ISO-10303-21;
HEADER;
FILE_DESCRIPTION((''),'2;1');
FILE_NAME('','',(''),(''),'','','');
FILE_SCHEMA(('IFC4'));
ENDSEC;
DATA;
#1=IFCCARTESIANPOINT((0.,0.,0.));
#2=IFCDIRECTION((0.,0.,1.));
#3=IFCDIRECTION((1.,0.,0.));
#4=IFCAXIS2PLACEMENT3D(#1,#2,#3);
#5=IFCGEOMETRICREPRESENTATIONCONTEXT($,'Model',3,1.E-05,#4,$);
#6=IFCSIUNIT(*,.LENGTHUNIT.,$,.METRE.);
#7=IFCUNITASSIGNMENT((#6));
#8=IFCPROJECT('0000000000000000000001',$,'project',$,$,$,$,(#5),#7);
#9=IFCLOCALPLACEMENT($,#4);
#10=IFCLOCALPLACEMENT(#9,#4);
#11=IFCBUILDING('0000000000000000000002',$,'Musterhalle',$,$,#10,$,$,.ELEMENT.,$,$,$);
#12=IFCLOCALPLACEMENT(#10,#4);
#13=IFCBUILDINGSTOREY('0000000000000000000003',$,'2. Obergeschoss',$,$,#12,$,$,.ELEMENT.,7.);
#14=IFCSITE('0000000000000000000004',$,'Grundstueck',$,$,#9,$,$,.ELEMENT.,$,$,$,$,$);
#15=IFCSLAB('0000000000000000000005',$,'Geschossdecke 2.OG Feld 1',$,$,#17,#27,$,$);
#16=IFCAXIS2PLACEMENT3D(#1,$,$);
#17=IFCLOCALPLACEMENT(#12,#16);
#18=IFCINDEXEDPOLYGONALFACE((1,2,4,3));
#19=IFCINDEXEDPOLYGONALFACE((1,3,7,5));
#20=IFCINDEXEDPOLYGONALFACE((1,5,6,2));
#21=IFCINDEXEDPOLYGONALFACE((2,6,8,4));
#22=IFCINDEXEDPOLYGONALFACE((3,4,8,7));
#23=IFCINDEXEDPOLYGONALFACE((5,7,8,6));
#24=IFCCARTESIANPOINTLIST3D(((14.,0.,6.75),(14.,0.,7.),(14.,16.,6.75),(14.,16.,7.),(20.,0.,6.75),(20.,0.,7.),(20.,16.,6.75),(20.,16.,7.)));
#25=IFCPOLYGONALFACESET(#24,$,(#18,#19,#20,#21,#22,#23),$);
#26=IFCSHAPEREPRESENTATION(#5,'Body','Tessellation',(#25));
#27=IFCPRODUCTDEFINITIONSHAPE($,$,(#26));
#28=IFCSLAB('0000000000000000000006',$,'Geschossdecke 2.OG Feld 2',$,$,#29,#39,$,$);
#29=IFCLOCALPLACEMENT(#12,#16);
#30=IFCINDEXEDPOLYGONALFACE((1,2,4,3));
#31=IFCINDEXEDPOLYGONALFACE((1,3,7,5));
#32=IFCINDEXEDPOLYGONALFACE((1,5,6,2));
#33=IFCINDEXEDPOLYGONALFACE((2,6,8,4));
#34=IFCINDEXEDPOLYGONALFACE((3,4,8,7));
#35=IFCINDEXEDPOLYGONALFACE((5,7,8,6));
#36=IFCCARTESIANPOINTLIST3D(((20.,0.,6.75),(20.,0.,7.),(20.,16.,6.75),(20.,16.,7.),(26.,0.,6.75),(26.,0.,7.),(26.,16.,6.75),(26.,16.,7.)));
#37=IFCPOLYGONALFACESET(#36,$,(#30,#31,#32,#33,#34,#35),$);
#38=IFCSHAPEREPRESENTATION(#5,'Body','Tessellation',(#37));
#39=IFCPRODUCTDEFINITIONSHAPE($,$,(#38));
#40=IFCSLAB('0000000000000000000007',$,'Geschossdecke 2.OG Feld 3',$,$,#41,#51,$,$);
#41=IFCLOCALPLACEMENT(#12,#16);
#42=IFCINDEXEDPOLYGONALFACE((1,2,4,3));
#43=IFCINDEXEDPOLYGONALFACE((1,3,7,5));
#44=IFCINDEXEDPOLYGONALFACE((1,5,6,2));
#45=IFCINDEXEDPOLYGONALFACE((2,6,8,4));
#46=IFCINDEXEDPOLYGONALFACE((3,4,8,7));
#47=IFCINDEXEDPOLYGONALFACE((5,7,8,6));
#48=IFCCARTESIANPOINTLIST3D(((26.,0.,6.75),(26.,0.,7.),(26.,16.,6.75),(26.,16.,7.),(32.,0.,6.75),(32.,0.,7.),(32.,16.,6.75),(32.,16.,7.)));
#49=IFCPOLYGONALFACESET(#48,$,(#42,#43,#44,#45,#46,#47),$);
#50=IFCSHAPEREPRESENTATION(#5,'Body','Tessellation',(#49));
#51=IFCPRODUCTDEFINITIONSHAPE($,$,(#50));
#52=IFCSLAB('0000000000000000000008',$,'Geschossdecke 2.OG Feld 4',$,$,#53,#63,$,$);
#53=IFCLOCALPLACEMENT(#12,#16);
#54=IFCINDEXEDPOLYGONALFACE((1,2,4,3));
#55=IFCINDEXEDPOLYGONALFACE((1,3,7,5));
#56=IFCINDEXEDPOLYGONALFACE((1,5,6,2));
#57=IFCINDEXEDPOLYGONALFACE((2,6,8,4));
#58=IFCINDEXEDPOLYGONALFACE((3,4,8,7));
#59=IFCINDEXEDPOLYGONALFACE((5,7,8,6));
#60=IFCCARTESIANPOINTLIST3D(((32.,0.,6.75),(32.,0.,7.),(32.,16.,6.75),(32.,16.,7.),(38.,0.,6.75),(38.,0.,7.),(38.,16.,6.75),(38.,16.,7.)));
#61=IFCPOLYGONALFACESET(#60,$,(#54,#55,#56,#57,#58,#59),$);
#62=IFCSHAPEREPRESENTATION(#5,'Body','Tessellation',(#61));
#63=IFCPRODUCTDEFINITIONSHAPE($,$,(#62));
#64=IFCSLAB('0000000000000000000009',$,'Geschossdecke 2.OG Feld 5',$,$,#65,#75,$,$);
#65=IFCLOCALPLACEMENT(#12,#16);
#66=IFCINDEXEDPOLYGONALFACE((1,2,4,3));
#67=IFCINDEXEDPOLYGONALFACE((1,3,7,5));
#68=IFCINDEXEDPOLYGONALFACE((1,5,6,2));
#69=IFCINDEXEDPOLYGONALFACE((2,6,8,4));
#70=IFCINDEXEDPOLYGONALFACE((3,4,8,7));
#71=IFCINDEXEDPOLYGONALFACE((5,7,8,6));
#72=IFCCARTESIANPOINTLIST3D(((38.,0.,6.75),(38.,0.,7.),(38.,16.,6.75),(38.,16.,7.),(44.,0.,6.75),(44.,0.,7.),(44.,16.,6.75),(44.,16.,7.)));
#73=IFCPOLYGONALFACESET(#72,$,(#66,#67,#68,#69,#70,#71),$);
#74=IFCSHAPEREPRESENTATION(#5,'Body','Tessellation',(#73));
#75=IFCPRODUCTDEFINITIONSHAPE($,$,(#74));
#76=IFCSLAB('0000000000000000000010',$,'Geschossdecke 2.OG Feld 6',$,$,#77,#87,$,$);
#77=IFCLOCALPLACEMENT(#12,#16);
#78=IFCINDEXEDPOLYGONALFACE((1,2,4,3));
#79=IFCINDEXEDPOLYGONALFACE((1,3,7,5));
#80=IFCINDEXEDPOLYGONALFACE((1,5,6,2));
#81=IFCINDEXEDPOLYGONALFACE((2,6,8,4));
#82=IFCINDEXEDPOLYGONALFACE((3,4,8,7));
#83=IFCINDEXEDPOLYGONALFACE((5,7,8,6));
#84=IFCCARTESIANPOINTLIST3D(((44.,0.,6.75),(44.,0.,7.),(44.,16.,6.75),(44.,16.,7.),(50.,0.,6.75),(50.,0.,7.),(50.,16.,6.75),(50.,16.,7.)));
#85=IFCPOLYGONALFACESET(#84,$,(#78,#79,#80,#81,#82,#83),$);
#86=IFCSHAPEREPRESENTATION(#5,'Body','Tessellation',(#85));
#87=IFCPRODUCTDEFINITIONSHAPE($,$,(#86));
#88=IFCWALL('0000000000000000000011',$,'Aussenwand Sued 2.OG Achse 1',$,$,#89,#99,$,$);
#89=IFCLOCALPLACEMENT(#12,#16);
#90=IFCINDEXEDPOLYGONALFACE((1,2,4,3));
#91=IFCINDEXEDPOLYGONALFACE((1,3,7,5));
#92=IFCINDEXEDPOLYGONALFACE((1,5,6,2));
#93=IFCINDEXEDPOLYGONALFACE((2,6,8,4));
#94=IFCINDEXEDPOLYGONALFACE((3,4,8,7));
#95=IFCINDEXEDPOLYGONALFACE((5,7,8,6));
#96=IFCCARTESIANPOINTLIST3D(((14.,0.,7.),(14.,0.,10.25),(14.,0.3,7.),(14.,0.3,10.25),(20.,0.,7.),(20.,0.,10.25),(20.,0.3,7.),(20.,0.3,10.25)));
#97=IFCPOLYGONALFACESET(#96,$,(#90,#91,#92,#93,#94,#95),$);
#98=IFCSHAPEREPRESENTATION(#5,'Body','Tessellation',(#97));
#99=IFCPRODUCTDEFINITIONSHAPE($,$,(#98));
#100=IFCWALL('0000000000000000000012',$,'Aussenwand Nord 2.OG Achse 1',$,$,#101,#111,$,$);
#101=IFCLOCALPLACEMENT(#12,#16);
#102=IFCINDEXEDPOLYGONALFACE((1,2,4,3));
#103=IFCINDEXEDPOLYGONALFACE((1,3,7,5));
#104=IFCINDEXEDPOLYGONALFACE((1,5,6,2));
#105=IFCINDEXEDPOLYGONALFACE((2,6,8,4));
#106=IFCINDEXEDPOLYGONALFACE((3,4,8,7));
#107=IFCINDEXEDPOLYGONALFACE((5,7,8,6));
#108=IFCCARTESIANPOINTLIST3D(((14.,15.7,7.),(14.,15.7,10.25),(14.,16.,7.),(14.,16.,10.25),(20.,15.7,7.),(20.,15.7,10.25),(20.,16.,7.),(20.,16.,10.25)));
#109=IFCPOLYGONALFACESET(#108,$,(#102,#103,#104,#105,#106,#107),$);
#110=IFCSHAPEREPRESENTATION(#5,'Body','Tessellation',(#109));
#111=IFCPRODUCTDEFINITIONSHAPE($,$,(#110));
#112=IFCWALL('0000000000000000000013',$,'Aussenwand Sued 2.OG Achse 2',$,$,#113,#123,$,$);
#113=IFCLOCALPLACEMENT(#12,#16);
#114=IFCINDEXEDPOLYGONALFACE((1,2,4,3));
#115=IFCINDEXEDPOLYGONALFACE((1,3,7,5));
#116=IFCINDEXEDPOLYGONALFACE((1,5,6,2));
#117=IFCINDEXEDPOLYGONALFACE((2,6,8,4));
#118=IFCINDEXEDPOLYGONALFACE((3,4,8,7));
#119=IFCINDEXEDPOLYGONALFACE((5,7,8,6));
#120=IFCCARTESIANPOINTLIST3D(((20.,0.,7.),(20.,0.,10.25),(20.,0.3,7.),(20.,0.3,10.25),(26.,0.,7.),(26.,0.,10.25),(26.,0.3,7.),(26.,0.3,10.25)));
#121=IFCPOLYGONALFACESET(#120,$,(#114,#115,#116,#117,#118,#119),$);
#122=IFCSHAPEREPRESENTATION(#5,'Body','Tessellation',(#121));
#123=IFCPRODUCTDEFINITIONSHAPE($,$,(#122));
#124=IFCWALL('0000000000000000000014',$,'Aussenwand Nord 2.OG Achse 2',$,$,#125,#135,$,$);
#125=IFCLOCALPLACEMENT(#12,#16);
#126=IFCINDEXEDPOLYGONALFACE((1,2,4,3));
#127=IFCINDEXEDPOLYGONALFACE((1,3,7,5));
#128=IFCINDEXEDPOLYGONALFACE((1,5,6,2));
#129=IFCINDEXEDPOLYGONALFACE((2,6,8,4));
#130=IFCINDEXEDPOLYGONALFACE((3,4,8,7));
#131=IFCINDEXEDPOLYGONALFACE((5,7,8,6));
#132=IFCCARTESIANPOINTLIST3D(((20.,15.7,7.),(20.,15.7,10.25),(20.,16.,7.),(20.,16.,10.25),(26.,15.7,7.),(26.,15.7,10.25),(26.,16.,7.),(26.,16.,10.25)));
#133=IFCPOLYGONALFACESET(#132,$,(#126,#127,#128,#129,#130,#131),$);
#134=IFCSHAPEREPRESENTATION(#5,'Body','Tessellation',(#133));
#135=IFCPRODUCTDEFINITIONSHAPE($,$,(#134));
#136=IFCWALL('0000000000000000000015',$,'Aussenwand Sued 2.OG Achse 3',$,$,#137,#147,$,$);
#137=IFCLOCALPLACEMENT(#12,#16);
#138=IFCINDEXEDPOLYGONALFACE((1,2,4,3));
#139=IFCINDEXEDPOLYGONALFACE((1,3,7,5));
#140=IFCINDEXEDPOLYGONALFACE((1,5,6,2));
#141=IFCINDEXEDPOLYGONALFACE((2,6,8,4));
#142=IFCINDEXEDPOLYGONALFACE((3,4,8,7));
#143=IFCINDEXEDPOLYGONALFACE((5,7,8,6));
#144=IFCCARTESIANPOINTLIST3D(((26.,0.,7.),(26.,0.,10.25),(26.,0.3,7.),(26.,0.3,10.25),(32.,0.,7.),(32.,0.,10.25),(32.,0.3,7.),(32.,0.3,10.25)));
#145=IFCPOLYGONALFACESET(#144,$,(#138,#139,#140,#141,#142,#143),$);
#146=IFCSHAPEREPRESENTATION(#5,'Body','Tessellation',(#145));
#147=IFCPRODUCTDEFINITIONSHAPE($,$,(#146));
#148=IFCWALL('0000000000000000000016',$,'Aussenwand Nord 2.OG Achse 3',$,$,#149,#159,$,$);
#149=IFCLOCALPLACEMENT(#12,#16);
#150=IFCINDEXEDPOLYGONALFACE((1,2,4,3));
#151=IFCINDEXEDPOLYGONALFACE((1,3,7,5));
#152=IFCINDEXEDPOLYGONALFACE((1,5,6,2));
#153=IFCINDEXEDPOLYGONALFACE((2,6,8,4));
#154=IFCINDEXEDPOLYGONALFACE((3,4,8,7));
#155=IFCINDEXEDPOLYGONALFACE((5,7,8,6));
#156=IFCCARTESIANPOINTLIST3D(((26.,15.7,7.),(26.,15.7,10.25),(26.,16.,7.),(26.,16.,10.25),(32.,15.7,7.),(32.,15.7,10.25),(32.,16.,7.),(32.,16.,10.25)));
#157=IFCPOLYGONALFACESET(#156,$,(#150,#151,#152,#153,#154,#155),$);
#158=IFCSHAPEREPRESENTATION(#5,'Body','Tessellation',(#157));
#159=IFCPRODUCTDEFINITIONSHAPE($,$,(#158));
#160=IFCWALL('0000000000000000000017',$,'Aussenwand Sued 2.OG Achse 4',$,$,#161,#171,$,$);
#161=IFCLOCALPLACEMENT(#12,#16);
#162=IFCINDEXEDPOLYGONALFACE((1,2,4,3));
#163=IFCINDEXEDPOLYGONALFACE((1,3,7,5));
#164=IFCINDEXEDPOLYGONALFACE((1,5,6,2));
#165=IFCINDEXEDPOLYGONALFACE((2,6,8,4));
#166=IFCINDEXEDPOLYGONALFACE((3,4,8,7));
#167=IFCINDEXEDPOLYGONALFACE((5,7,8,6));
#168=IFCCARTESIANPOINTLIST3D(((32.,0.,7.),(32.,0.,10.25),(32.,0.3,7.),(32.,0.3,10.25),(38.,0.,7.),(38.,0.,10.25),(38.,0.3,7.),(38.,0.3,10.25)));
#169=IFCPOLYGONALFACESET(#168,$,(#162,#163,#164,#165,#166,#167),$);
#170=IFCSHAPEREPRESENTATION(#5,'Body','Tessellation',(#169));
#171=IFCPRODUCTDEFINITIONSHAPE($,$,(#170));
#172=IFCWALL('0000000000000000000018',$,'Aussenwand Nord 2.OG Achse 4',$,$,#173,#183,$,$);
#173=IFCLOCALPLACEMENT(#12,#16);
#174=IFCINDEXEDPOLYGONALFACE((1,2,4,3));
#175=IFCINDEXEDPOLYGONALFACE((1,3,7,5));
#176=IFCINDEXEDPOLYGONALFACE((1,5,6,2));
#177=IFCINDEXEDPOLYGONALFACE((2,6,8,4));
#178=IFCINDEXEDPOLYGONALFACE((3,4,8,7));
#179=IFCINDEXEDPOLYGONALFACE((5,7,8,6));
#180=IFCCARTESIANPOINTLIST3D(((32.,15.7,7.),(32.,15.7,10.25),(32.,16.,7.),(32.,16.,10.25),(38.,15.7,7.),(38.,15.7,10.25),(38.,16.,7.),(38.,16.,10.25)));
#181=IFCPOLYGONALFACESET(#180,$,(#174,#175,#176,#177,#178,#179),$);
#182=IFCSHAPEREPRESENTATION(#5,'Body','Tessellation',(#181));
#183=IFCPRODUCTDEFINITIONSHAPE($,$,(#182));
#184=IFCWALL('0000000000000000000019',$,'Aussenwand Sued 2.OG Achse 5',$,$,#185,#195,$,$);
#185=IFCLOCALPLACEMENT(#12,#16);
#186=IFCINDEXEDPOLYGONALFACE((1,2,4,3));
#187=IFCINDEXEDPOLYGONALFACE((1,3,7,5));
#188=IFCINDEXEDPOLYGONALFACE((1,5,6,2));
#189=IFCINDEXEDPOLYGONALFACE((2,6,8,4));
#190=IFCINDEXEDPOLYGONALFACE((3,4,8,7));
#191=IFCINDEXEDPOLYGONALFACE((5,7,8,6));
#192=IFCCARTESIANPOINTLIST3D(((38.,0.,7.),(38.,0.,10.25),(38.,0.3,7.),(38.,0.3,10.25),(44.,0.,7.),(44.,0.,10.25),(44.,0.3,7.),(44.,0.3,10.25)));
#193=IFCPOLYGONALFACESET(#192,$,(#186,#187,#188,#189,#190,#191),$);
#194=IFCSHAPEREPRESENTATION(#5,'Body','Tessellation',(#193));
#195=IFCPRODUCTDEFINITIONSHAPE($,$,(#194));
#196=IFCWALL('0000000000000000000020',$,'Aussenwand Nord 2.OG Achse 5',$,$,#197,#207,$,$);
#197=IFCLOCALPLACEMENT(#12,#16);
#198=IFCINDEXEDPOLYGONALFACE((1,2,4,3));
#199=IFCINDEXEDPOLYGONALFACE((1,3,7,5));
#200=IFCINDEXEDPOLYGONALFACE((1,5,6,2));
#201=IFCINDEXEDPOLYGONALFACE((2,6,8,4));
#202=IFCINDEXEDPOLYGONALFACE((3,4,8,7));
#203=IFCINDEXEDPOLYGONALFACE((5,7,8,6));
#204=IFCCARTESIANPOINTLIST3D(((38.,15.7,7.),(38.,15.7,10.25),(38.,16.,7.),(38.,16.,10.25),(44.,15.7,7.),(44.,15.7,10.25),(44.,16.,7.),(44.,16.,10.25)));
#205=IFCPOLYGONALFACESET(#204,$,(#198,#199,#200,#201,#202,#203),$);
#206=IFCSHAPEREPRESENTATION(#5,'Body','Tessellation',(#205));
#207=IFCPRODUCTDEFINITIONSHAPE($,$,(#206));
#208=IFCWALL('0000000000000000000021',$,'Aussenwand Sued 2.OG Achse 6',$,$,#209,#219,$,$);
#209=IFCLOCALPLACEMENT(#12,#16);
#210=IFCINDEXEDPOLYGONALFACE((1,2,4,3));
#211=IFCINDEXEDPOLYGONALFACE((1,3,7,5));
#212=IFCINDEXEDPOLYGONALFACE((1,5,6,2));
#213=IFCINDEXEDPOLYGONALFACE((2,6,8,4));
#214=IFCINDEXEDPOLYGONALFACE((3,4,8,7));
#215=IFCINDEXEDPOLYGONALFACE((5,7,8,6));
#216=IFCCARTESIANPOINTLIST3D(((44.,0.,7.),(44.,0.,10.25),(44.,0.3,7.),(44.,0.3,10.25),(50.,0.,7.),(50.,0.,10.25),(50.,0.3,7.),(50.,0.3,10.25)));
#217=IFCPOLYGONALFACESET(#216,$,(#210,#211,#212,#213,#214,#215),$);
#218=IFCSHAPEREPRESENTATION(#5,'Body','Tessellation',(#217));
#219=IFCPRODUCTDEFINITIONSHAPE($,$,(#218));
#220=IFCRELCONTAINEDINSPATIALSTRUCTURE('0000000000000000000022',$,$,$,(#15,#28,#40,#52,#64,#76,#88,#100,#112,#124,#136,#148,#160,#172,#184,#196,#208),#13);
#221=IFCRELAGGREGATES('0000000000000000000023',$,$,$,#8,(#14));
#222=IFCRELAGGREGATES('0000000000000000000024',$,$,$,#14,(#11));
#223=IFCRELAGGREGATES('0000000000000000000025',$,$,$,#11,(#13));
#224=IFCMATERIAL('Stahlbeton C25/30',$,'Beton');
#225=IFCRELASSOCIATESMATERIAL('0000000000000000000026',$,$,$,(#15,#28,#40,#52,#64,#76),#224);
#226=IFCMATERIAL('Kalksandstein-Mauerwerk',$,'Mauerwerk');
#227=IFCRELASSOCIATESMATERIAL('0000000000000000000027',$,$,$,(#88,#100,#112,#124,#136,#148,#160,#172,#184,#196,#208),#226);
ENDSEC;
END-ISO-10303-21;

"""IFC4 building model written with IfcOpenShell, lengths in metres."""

from ifc_helpers import new_model, si_unit, frame, origin_with_axes, origin_2d, place, context, project, spatial, rectangle, extrude, material, element, save


model = new_model("IFC4")

# Units and contexts
model_context = context("Model", 3, precision=1e-05, world=origin_with_axes())
ifc_project = project(units=[si_unit("LENGTHUNIT", "METRE")], contexts=[model_context])

# Site, building, storey
site_placement = place(None, origin_with_axes())
site = spatial("IfcSite", under=ifc_project, at=site_placement, Name="Grundstueck", CompositionType="ELEMENT")
building_placement = place(site_placement, origin_with_axes())
building = spatial("IfcBuilding", under=site, at=building_placement, Name="Musterhalle", CompositionType="ELEMENT")
storey_placement = place(building_placement, origin_with_axes())
storey = spatial("IfcBuildingStorey", under=building, at=storey_placement, Name="2. Obergeschoss", CompositionType="ELEMENT", Elevation=7.0)

# Slabs
ifc_material_1 = material(Name="Stahlbeton C25/30", Category="Beton")
placement = place(storey_placement, origin_with_axes())
element("IfcSlab", 1, at=placement, inside=storey, material=ifc_material_1, Name="Geschossdecke 2.OG Feld 1", context=model_context, shape_type="SweptSolid", body=[
    extrude(rectangle(XDim=6.0, YDim=16.0, at=origin_2d()), frame((17.0, 8.0, 6.75), z_axis=(0.0, 0.0, 1.0), x_axis=(1.0, 0.0, 0.0)), (0.0, 0.0, 1.0), 0.25),
])
element("IfcSlab", 2, at=placement, inside=storey, material=ifc_material_1, Name="Geschossdecke 2.OG Feld 2", context=model_context, shape_type="SweptSolid", body=[
    extrude(rectangle(XDim=6.0, YDim=16.0, at=origin_2d()), frame((23.0, 8.0, 6.75), z_axis=(0.0, 0.0, 1.0), x_axis=(1.0, 0.0, 0.0)), (0.0, 0.0, 1.0), 0.25),
])
element("IfcSlab", 3, at=placement, inside=storey, material=ifc_material_1, Name="Geschossdecke 2.OG Feld 3", context=model_context, shape_type="SweptSolid", body=[
    extrude(rectangle(XDim=6.0, YDim=16.0, at=origin_2d()), frame((29.0, 8.0, 6.75), z_axis=(0.0, 0.0, 1.0), x_axis=(1.0, 0.0, 0.0)), (0.0, 0.0, 1.0), 0.25),
])
element("IfcSlab", 4, at=placement, inside=storey, material=ifc_material_1, Name="Geschossdecke 2.OG Feld 4", context=model_context, shape_type="SweptSolid", body=[
    extrude(rectangle(XDim=6.0, YDim=16.0, at=origin_2d()), frame((35.0, 8.0, 6.75), z_axis=(0.0, 0.0, 1.0), x_axis=(1.0, 0.0, 0.0)), (0.0, 0.0, 1.0), 0.25),
])
element("IfcSlab", 5, at=placement, inside=storey, material=ifc_material_1, Name="Geschossdecke 2.OG Feld 5", context=model_context, shape_type="SweptSolid", body=[
    extrude(rectangle(XDim=6.0, YDim=16.0, at=origin_2d()), frame((41.0, 8.0, 6.75), z_axis=(0.0, 0.0, 1.0), x_axis=(1.0, 0.0, 0.0)), (0.0, 0.0, 1.0), 0.25),
])
element("IfcSlab", 6, at=placement, inside=storey, material=ifc_material_1, Name="Geschossdecke 2.OG Feld 6", context=model_context, shape_type="SweptSolid", body=[
    extrude(rectangle(XDim=6.0, YDim=16.0, at=origin_2d()), frame((47.0, 8.0, 6.75), z_axis=(0.0, 0.0, 1.0), x_axis=(1.0, 0.0, 0.0)), (0.0, 0.0, 1.0), 0.25),
])

# Walls
ifc_material_2 = material(Name="Kalksandstein-Mauerwerk", Category="Mauerwerk")
element("IfcWall", 7, at=placement, inside=storey, material=ifc_material_2, Name="Aussenwand Sued 2.OG Achse 1", context=model_context, shape_type="SweptSolid", body=[
    extrude(rectangle(XDim=6.0, YDim=0.3, at=origin_2d()), frame((17.0, 0.15, 7.0), z_axis=(0.0, 0.0, 1.0), x_axis=(1.0, 0.0, 0.0)), (0.0, 0.0, 1.0), 3.25),
])
element("IfcWall", 8, at=placement, inside=storey, material=ifc_material_2, Name="Aussenwand Nord 2.OG Achse 1", context=model_context, shape_type="SweptSolid", body=[
    extrude(rectangle(XDim=6.0, YDim=0.3, at=origin_2d()), frame((17.0, 15.85, 7.0), z_axis=(0.0, 0.0, 1.0), x_axis=(1.0, 0.0, 0.0)), (0.0, 0.0, 1.0), 3.25),
])
element("IfcWall", 9, at=placement, inside=storey, material=ifc_material_2, Name="Aussenwand Sued 2.OG Achse 2", context=model_context, shape_type="SweptSolid", body=[
    extrude(rectangle(XDim=6.0, YDim=0.3, at=origin_2d()), frame((23.0, 0.15, 7.0), z_axis=(0.0, 0.0, 1.0), x_axis=(1.0, 0.0, 0.0)), (0.0, 0.0, 1.0), 3.25),
])
element("IfcWall", 10, at=placement, inside=storey, material=ifc_material_2, Name="Aussenwand Nord 2.OG Achse 2", context=model_context, shape_type="SweptSolid", body=[
    extrude(rectangle(XDim=6.0, YDim=0.3, at=origin_2d()), frame((23.0, 15.85, 7.0), z_axis=(0.0, 0.0, 1.0), x_axis=(1.0, 0.0, 0.0)), (0.0, 0.0, 1.0), 3.25),
])
element("IfcWall", 11, at=placement, inside=storey, material=ifc_material_2, Name="Aussenwand Sued 2.OG Achse 3", context=model_context, shape_type="SweptSolid", body=[
    extrude(rectangle(XDim=6.0, YDim=0.3, at=origin_2d()), frame((29.0, 0.15, 7.0), z_axis=(0.0, 0.0, 1.0), x_axis=(1.0, 0.0, 0.0)), (0.0, 0.0, 1.0), 3.25),
])
element("IfcWall", 12, at=placement, inside=storey, material=ifc_material_2, Name="Aussenwand Nord 2.OG Achse 3", context=model_context, shape_type="SweptSolid", body=[
    extrude(rectangle(XDim=6.0, YDim=0.3, at=origin_2d()), frame((29.0, 15.85, 7.0), z_axis=(0.0, 0.0, 1.0), x_axis=(1.0, 0.0, 0.0)), (0.0, 0.0, 1.0), 3.25),
])
element("IfcWall", 13, at=placement, inside=storey, material=ifc_material_2, Name="Aussenwand Sued 2.OG Achse 4", context=model_context, shape_type="SweptSolid", body=[
    extrude(rectangle(XDim=6.0, YDim=0.3, at=origin_2d()), frame((35.0, 0.15, 7.0), z_axis=(0.0, 0.0, 1.0), x_axis=(1.0, 0.0, 0.0)), (0.0, 0.0, 1.0), 3.25),
])
element("IfcWall", 14, at=placement, inside=storey, material=ifc_material_2, Name="Aussenwand Nord 2.OG Achse 4", context=model_context, shape_type="SweptSolid", body=[
    extrude(rectangle(XDim=6.0, YDim=0.3, at=origin_2d()), frame((35.0, 15.85, 7.0), z_axis=(0.0, 0.0, 1.0), x_axis=(1.0, 0.0, 0.0)), (0.0, 0.0, 1.0), 3.25),
])
element("IfcWall", 15, at=placement, inside=storey, material=ifc_material_2, Name="Aussenwand Sued 2.OG Achse 5", context=model_context, shape_type="SweptSolid", body=[
    extrude(rectangle(XDim=6.0, YDim=0.3, at=origin_2d()), frame((41.0, 0.15, 7.0), z_axis=(0.0, 0.0, 1.0), x_axis=(1.0, 0.0, 0.0)), (0.0, 0.0, 1.0), 3.25),
])
element("IfcWall", 16, at=placement, inside=storey, material=ifc_material_2, Name="Aussenwand Nord 2.OG Achse 5", context=model_context, shape_type="SweptSolid", body=[
    extrude(rectangle(XDim=6.0, YDim=0.3, at=origin_2d()), frame((41.0, 15.85, 7.0), z_axis=(0.0, 0.0, 1.0), x_axis=(1.0, 0.0, 0.0)), (0.0, 0.0, 1.0), 3.25),
])
element("IfcWall", 17, at=placement, inside=storey, material=ifc_material_2, Name="Aussenwand Sued 2.OG Achse 6", context=model_context, shape_type="SweptSolid", body=[
    extrude(rectangle(XDim=6.0, YDim=0.3, at=origin_2d()), frame((47.0, 0.15, 7.0), z_axis=(0.0, 0.0, 1.0), x_axis=(1.0, 0.0, 0.0)), (0.0, 0.0, 1.0), 3.25),
])

save(model, "model.ifc")
